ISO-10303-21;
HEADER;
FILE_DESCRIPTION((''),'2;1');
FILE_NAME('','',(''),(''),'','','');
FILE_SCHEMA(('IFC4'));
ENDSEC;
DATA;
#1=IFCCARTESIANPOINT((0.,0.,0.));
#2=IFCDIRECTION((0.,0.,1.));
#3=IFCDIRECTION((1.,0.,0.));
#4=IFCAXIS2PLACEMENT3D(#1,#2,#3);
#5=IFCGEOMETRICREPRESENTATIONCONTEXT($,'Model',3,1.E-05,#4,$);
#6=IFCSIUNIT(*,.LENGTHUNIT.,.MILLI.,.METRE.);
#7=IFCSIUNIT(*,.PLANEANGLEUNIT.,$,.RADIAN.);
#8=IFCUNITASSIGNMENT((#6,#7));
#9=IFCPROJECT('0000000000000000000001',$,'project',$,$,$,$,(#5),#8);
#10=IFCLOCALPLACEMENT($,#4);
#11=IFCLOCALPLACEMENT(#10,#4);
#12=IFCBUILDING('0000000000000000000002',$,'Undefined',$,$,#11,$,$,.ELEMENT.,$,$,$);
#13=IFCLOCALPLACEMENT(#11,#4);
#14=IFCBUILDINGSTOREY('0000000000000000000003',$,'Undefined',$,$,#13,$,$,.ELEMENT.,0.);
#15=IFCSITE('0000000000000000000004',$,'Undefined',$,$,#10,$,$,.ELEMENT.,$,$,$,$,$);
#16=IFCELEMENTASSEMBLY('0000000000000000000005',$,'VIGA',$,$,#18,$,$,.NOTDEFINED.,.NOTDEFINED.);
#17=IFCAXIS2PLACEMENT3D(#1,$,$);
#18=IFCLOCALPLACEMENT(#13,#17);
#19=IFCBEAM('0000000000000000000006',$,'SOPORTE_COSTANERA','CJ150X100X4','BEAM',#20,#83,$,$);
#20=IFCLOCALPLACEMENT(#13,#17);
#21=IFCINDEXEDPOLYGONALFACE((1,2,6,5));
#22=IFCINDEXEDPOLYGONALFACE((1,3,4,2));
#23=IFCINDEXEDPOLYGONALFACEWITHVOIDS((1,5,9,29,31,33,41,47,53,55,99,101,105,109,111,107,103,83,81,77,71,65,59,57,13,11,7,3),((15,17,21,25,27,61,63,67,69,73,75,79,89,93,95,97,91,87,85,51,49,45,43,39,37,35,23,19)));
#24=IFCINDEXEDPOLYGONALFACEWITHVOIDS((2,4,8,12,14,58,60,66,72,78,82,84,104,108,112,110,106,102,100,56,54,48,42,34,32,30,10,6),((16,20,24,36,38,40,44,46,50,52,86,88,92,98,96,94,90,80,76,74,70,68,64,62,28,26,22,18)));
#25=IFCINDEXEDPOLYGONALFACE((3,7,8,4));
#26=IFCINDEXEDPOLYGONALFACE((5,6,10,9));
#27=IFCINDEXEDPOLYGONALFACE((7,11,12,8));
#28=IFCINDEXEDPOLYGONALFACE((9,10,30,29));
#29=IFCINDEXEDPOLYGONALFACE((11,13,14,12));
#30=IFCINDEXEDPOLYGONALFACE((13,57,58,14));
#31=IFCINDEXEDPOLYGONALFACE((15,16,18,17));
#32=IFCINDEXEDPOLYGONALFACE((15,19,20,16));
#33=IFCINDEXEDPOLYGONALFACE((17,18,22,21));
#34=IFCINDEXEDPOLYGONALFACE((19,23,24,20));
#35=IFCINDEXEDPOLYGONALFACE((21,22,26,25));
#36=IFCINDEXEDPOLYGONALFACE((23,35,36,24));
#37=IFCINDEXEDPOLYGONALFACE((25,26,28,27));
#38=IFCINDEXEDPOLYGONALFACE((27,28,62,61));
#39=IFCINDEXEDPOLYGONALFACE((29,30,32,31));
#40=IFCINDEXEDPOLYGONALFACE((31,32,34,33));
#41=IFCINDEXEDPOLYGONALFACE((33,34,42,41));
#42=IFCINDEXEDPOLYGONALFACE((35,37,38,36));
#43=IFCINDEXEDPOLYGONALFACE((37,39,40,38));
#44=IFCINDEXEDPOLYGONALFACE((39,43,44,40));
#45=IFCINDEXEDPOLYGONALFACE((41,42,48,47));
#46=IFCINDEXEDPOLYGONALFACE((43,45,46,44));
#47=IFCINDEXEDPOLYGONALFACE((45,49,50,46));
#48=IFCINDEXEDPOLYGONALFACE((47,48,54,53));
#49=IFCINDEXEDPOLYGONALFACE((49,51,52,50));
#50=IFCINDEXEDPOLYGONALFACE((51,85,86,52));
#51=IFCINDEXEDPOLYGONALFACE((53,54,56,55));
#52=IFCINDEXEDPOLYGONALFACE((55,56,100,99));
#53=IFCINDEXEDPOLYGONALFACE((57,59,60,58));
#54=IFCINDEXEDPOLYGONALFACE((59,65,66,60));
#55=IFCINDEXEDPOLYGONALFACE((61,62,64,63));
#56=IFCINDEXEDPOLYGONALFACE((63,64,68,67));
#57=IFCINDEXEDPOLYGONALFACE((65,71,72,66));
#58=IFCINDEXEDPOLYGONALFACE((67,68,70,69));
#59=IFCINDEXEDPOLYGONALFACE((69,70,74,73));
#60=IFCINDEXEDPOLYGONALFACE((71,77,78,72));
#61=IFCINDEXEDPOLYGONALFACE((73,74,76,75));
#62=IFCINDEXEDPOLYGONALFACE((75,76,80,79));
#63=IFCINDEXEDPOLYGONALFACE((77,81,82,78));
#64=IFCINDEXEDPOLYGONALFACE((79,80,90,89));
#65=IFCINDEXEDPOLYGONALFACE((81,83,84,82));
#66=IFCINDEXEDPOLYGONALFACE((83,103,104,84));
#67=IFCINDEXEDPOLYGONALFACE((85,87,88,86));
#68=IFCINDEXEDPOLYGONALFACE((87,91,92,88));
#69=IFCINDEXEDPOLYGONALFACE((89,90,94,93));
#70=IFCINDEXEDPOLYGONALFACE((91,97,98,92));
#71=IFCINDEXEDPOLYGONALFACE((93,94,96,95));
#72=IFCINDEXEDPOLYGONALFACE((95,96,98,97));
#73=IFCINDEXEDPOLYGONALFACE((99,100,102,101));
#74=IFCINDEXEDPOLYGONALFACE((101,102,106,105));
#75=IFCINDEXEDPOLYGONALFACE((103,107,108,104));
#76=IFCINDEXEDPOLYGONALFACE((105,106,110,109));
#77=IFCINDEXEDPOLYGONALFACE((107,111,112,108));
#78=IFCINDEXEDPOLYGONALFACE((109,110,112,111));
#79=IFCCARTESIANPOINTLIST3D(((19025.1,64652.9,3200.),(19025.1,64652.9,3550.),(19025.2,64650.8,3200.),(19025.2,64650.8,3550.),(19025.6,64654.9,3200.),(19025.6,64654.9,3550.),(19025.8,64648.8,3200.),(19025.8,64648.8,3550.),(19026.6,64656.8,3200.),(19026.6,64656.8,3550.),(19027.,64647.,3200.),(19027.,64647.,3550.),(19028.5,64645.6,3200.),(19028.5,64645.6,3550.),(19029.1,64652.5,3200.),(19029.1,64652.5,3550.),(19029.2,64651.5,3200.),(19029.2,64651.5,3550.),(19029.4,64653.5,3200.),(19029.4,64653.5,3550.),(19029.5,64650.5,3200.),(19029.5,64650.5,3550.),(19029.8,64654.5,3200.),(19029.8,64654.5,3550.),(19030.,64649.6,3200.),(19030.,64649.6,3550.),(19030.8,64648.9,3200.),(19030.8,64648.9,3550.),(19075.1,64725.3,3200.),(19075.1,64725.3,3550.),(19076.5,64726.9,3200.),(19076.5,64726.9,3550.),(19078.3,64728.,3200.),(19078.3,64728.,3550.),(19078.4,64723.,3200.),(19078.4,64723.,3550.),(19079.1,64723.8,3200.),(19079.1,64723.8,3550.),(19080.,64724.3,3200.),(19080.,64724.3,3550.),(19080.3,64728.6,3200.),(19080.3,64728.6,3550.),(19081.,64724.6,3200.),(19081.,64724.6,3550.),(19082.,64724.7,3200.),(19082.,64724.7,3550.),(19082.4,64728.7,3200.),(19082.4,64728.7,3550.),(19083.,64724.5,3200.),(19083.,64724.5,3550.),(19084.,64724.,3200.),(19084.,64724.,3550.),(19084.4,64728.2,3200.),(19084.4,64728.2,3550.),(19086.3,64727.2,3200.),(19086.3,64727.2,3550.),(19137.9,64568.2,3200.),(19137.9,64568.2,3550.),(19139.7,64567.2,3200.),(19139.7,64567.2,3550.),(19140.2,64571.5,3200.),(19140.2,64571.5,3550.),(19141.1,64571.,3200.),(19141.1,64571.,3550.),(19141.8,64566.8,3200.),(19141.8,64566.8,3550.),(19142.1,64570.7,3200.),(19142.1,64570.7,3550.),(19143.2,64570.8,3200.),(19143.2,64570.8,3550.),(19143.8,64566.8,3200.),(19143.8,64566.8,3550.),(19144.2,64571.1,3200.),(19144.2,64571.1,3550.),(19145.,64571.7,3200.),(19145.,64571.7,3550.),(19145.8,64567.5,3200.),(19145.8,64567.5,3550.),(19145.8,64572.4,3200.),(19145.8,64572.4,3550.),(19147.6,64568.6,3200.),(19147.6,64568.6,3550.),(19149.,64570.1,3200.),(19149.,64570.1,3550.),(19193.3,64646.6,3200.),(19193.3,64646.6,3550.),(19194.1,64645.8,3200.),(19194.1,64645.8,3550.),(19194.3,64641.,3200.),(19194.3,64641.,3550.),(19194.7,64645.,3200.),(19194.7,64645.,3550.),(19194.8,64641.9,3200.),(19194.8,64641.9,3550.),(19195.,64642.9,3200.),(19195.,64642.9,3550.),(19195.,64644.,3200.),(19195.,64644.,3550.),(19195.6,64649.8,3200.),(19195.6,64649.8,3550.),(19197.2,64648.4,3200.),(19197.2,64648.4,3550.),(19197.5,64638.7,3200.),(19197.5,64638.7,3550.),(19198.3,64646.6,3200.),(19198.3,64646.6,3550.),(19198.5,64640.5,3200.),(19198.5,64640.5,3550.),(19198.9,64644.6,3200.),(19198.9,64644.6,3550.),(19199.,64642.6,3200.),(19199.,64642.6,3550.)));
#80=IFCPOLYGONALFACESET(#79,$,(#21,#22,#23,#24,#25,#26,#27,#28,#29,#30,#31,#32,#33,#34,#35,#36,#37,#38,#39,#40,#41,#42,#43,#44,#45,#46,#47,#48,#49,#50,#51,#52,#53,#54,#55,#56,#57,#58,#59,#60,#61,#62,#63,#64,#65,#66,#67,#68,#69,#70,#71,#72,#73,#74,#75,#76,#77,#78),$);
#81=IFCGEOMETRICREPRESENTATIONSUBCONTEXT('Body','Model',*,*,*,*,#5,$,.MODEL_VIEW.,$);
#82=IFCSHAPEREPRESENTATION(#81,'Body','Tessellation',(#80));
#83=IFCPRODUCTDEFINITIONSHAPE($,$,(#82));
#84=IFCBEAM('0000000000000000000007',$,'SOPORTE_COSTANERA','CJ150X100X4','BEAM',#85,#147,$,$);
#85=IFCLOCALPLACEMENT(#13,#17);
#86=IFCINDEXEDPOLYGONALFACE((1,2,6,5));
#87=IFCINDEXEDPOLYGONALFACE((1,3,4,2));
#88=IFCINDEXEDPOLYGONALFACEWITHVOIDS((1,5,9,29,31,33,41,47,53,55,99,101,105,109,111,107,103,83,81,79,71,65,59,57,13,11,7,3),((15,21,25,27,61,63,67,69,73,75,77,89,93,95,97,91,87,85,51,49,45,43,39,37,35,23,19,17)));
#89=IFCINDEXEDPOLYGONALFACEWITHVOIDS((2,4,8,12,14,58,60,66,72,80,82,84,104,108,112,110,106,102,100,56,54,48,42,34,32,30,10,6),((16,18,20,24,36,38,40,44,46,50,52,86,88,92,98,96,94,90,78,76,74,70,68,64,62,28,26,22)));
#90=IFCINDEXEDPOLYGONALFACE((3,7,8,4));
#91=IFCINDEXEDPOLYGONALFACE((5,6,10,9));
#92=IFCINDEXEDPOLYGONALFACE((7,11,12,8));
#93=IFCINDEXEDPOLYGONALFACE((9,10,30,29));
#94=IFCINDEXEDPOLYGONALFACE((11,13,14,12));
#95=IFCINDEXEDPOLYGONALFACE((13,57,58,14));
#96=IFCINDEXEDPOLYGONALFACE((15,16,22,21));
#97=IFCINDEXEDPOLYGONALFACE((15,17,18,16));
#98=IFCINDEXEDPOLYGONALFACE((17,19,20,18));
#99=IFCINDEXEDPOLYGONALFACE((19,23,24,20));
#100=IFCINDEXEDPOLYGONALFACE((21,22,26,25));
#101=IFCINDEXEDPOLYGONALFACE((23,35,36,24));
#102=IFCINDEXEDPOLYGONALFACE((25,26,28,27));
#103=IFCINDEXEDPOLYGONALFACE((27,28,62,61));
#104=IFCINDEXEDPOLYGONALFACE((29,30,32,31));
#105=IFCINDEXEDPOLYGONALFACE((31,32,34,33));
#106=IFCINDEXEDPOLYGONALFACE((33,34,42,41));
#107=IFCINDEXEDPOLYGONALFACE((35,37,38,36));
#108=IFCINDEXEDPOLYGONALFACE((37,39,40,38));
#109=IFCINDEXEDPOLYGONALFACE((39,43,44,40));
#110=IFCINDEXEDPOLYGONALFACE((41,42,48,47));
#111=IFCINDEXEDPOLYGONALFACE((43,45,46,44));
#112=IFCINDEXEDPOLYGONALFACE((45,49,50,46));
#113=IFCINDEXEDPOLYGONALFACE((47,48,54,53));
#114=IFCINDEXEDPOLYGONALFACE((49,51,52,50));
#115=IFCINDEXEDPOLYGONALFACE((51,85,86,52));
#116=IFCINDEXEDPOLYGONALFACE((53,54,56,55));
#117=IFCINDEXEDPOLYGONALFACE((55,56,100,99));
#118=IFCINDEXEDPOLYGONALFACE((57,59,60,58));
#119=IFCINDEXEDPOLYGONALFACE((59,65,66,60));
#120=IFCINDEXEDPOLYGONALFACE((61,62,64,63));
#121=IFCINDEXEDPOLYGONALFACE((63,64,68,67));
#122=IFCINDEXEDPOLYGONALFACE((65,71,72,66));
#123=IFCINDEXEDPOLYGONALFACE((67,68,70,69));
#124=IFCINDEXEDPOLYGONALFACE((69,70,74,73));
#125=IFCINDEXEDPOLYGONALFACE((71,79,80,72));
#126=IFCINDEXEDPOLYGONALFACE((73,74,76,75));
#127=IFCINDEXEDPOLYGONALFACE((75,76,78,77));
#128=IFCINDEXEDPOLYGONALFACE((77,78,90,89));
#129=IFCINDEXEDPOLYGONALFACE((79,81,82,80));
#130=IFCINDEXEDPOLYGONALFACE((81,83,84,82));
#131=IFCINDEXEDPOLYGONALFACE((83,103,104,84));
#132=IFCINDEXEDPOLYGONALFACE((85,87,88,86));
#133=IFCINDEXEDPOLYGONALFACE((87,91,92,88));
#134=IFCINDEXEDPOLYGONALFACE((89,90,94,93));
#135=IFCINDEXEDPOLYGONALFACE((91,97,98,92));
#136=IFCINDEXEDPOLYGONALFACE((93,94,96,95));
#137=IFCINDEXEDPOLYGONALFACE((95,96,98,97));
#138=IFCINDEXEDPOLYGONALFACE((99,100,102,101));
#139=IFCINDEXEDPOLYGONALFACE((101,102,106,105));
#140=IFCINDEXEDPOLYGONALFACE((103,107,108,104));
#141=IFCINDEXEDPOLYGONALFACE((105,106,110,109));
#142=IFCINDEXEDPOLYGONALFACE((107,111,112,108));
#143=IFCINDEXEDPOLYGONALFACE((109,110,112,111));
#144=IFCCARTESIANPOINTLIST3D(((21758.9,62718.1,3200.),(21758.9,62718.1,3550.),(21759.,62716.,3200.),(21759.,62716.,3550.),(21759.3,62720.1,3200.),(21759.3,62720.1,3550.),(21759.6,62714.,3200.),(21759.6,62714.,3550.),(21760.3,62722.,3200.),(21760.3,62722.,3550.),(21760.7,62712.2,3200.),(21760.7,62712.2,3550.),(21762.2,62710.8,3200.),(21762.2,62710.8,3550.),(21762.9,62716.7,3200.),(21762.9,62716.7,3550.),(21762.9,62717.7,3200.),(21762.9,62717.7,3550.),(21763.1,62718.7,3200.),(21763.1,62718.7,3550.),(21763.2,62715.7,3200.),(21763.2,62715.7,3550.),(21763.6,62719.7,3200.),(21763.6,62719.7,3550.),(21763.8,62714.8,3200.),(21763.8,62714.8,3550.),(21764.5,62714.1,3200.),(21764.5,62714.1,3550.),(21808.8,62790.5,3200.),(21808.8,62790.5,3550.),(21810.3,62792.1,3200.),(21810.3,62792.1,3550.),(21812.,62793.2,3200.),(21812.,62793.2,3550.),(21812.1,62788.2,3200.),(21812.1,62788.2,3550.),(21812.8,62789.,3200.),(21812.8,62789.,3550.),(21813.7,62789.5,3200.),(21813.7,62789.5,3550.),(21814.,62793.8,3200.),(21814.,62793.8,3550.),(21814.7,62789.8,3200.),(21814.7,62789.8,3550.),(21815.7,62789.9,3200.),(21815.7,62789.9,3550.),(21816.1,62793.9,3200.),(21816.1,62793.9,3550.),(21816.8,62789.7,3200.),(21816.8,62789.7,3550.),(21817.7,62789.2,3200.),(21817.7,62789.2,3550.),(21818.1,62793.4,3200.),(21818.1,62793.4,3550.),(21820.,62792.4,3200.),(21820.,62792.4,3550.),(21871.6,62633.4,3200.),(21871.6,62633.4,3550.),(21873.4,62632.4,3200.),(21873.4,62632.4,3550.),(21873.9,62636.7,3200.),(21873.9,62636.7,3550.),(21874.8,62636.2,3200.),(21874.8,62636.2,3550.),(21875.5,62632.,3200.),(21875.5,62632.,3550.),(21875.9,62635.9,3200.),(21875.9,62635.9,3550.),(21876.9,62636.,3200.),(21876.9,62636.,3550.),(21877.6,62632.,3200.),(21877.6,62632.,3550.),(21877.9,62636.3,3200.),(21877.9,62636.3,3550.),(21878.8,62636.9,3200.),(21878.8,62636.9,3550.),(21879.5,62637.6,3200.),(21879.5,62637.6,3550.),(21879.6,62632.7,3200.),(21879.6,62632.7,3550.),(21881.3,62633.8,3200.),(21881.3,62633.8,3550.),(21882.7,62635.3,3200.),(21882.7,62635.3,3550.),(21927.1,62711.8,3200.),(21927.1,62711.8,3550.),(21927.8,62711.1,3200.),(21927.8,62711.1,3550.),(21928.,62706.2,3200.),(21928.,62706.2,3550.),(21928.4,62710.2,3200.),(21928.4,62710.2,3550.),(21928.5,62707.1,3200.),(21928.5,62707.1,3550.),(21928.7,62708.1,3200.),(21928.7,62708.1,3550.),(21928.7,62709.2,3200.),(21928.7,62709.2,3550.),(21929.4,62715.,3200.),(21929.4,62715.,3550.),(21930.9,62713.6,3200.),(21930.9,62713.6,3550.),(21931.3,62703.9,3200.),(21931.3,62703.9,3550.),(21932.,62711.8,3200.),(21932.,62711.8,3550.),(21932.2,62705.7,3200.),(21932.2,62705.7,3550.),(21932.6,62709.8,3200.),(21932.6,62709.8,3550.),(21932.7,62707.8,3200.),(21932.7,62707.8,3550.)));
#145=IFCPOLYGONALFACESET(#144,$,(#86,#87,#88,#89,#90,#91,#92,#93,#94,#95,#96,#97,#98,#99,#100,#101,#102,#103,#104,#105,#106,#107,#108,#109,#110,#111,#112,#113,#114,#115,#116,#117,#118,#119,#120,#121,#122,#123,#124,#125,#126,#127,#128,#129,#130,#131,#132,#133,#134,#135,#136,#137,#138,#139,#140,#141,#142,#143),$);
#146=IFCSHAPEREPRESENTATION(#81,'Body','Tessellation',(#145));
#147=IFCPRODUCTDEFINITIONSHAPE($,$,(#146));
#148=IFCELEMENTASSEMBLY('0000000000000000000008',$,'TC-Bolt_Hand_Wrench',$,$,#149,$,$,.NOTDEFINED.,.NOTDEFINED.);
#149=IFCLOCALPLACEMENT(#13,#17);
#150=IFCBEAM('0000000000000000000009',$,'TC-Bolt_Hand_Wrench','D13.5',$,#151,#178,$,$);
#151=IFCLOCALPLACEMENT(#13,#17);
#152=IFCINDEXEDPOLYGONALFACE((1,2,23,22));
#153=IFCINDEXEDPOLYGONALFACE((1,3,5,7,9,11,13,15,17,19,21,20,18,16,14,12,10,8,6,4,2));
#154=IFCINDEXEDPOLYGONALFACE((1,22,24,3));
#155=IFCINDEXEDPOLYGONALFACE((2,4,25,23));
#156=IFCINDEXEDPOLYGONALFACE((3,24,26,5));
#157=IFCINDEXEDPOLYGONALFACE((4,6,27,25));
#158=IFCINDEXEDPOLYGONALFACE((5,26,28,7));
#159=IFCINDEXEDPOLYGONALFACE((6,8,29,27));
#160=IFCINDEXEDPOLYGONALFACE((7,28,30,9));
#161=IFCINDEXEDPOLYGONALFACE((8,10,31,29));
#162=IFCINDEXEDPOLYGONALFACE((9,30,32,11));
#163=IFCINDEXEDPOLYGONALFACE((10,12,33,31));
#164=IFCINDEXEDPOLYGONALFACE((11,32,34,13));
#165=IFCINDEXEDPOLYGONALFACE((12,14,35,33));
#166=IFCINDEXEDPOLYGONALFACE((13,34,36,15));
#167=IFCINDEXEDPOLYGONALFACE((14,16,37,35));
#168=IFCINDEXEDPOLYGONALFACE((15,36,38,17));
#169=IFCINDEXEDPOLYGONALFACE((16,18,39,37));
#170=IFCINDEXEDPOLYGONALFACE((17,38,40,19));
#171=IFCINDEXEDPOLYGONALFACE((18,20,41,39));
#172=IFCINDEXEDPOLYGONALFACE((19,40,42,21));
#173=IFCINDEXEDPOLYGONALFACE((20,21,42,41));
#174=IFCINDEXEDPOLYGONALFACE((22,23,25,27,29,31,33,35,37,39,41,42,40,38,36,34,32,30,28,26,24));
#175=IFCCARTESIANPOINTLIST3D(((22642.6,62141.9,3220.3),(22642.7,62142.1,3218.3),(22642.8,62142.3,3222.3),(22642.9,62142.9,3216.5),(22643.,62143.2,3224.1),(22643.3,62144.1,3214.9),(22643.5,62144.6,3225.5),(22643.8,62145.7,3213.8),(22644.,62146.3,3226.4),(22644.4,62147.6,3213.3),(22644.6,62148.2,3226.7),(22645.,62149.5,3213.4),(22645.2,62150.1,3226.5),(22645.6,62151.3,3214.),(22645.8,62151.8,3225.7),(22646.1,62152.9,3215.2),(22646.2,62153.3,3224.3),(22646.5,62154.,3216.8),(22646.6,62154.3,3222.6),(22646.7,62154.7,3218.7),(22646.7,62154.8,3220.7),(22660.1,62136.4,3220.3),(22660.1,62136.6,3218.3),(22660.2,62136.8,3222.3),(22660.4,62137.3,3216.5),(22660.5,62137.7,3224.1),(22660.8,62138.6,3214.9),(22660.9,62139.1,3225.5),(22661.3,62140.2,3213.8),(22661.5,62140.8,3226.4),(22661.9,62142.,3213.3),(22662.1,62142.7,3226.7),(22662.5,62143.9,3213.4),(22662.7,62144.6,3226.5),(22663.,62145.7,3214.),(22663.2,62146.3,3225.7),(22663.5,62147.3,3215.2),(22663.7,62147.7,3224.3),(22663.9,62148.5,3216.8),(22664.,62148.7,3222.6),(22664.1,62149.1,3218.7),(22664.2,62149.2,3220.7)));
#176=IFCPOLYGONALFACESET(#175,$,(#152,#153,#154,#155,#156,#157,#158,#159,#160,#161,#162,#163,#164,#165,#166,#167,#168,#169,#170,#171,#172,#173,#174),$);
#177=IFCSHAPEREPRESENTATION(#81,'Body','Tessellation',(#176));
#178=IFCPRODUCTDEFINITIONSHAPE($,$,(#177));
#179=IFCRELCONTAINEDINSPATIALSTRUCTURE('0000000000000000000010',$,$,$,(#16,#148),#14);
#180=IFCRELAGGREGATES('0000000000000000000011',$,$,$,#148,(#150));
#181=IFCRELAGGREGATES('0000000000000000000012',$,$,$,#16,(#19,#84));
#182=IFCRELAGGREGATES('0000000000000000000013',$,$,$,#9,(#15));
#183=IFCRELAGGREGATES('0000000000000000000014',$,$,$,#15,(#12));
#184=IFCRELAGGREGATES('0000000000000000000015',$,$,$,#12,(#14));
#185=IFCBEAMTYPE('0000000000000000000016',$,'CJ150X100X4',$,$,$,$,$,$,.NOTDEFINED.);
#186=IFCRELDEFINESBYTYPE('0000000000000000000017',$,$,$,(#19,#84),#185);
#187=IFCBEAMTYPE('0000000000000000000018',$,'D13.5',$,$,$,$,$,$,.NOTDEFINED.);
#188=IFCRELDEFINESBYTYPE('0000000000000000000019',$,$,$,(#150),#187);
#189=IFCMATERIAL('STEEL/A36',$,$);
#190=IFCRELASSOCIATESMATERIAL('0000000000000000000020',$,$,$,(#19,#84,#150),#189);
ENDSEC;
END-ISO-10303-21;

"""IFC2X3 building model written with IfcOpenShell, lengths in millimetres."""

from ifc_helpers import new_model, si_unit, frame, origin_with_axes, origin_2d_with_axis, place, context, subcontext, project, spatial, hollow_rectangle, circle, extrude, material, type_object, element, aggregate, save


model = new_model("IFC2X3")

# Units and contexts
model_context = context("Model", 3, precision=1e-05, world=origin_with_axes())
body_context = subcontext(model_context, "Body", "Model", "MODEL_VIEW")
ifc_project = project(units=[si_unit("LENGTHUNIT", "METRE", prefix="MILLI"), si_unit("PLANEANGLEUNIT", "RADIAN")], contexts=[model_context])

# Site, building, storey
site_placement = place(None, origin_with_axes())
site = spatial("IfcSite", under=ifc_project, at=site_placement, Name="Undefined", CompositionType="ELEMENT")
building_placement = place(site_placement, origin_with_axes())
building = spatial("IfcBuilding", under=site, at=building_placement, Name="Undefined", CompositionType="ELEMENT")
storey_placement = place(building_placement, origin_with_axes())
storey = spatial("IfcBuildingStorey", under=building, at=storey_placement, Name="Undefined", CompositionType="ELEMENT", Elevation=0.0)

# Element assembly, beams
assembly_1_placement = place(storey_placement, origin_with_axes())
assembly_1 = element("IfcElementAssembly", 1, at=assembly_1_placement, inside=storey, Name="VIGA", AssemblyPlace="NOTDEFINED", PredefinedType="NOTDEFINED")
ifc_material_1 = material(Name="STEEL/A36")
beam_type_1 = type_object("IfcBeamType", Name="CJ150X100X4", PredefinedType="NOTDEFINED")
beam_1_placement = place(assembly_1_placement, frame((19112.1, 64647.7, 3550.0), z_axis=(-0.816249, 0.577701, 0.0), x_axis=(0.0, 0.0, -1.0)))
beam_1 = element("IfcBeam", 2, at=beam_1_placement, type_object=beam_type_1, material=ifc_material_1, Name="SOPORTE_COSTANERA", Description="CJ150X100X4", ObjectType="BEAM", context=body_context, shape_type="SweptSolid", body=[
    extrude(hollow_rectangle(XDim=100.0, YDim=150.0, WallThickness=4.0, InnerFilletRadius=4.0, OuterFilletRadius=8.0, at=origin_2d_with_axis()), frame((350.0, 0.0, 0.0), z_axis=(-1.0, 0.0, 0.0), x_axis=(0.0, -1.0, 0.0)), (0.0, 0.0, 1.0), 350.0),
])
beam_2_placement = place(assembly_1_placement, frame((21845.8, 62712.9, 3550.0), z_axis=(-0.816249, 0.577701, 0.0), x_axis=(0.0, 0.0, -1.0)))
beam_2 = element("IfcBeam", 3, at=beam_2_placement, type_object=beam_type_1, material=ifc_material_1, Name="SOPORTE_COSTANERA", Description="CJ150X100X4", ObjectType="BEAM", context=body_context, shape_type="SweptSolid", body=[
    extrude(hollow_rectangle(XDim=100.0, YDim=150.0, WallThickness=4.0, InnerFilletRadius=4.0, OuterFilletRadius=8.0, at=origin_2d_with_axis()), frame((350.0, 0.0, 0.0), z_axis=(-1.0, 0.0, 0.0), x_axis=(0.0, -1.0, 0.0)), (0.0, 0.0, 1.0), 350.0),
])

# Element assembly, beam
assembly_2_placement = place(storey_placement, origin_with_axes())
assembly_2 = element("IfcElementAssembly", 4, at=assembly_2_placement, inside=storey, Name="TC-Bolt_Hand_Wrench", AssemblyPlace="NOTDEFINED", PredefinedType="NOTDEFINED")
beam_type_2 = type_object("IfcBeamType", Name="D13.5", PredefinedType="NOTDEFINED")
beam_3_placement = place(assembly_2_placement, frame((22644.7, 62148.4, 3220.0), z_axis=(0.194835, 0.612548, -0.766044), x_axis=(0.952934, -0.303178, -0.00006)))
beam_3 = element("IfcBeam", 5, at=beam_3_placement, type_object=beam_type_2, material=ifc_material_1, Name="TC-Bolt_Hand_Wrench", Description="D13.5", context=body_context, shape_type="SweptSolid", body=[
    extrude(circle(Radius=6.8, at=origin_2d_with_axis()), frame((18.3, 0.0, 0.0), z_axis=(-1.0, 0.0, 0.0), x_axis=(0.0, -1.0, 0.0)), (0.0, 0.0, 1.0), 18.3),
])
aggregate(assembly_2, [beam_3])

aggregate(assembly_1, [beam_1, beam_2])

save(model, "model.ifc")
